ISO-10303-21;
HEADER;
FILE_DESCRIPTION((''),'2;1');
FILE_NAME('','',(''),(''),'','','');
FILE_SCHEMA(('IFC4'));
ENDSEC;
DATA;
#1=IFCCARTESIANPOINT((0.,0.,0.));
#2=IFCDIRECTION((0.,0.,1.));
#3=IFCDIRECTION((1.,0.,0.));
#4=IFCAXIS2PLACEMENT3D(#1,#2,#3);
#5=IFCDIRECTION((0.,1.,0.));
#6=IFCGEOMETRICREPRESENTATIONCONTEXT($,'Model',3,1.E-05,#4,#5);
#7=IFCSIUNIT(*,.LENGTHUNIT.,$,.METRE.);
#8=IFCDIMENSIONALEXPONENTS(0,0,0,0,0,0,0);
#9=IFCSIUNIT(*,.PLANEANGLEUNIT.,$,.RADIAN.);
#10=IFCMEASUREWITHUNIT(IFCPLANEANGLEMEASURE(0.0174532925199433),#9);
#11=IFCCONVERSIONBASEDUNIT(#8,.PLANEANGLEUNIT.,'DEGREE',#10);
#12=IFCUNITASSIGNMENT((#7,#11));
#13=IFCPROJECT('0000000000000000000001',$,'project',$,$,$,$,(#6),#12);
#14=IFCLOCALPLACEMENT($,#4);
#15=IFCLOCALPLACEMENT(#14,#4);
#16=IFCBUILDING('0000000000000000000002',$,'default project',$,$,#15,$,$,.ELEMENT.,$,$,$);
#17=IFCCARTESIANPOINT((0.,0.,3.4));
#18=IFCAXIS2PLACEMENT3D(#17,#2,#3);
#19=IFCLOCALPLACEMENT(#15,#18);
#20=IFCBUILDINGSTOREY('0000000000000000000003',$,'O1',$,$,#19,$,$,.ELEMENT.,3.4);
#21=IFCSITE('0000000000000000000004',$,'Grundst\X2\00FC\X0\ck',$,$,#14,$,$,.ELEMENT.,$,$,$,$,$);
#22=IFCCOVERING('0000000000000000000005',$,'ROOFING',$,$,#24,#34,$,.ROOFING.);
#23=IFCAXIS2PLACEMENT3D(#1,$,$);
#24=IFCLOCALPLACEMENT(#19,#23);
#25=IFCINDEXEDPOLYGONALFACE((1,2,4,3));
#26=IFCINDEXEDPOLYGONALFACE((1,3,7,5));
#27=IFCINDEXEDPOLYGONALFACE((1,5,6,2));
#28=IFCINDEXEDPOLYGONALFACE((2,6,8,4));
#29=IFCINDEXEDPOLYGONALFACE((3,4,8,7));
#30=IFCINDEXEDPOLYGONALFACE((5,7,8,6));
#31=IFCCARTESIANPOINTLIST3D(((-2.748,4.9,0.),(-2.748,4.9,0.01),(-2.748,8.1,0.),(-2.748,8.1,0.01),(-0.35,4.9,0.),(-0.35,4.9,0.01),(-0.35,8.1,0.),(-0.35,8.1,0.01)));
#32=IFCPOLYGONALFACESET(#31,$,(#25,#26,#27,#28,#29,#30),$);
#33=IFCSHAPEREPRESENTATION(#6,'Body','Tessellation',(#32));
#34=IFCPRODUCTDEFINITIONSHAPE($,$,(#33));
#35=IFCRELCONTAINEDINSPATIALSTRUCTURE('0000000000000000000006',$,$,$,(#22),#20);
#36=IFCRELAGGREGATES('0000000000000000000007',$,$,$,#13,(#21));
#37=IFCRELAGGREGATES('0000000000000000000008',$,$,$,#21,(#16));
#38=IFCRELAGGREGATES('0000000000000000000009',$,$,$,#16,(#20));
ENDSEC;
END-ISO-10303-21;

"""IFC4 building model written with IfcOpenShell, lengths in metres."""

from ifc_helpers import new_model, entity, si_unit, converted_unit, direction, frame, origin_with_axes, place, context, project, spatial, polyline, outline, extrude, element, save


model = new_model("IFC4")

# Units and contexts
model_context = context("Model", 3, precision=1e-05, world=origin_with_axes(), true_north=direction((0.0, 1.0, 0.0)))
ifc_project = project(units=[si_unit("LENGTHUNIT", "METRE"), converted_unit("PLANEANGLEUNIT", "DEGREE", entity("IfcPlaneAngleMeasure", 0.0174532925199433), si_unit("PLANEANGLEUNIT", "RADIAN"), dimensions=[0, 0, 0, 0, 0, 0, 0])], contexts=[model_context])

# Site, building, storey
site_placement = place(None, origin_with_axes())
site = spatial("IfcSite", under=ifc_project, at=site_placement, Name="Grundstück", CompositionType="ELEMENT")
building_placement = place(site_placement, origin_with_axes())
building = spatial("IfcBuilding", under=site, at=building_placement, Name="default project", CompositionType="ELEMENT")
placement_1 = place(building_placement, frame((0.0, 0.0, 3.4), z_axis=(0.0, 0.0, 1.0), x_axis=(1.0, 0.0, 0.0)))
storey = spatial("IfcBuildingStorey", under=building, at=placement_1, Name="O1", CompositionType="ELEMENT", Elevation=3.4)

# Shared definitions
slab_1_placement = place(placement_1, frame((0.0, 0.0, -0.4), z_axis=(0.0, 0.0, 1.0), x_axis=(1.0, 0.0, 0.0)))

# Covering
covering_1_placement = place(slab_1_placement, frame((0.0, 0.0, 0.2), z_axis=(0.0, 0.0, 1.0), x_axis=(1.0, 0.0, 0.0)))
element("IfcCovering", 1, at=covering_1_placement, inside=storey, Name="ROOFING", PredefinedType="ROOFING", context=model_context, shape_type="SweptSolid", body=[
    extrude(outline(polyline([(-0.35, 8.1), (-2.748, 8.1), (-2.748, 4.9), (-0.35, 4.9), (-0.35, 8.1)])), frame((0.0, 0.0, 0.2), z_axis=(0.0, 0.0, 1.0), x_axis=(1.0, 0.0, 0.0)), (0.0, 0.0, 1.0), 0.01),
])

save(model, "model.ifc")
